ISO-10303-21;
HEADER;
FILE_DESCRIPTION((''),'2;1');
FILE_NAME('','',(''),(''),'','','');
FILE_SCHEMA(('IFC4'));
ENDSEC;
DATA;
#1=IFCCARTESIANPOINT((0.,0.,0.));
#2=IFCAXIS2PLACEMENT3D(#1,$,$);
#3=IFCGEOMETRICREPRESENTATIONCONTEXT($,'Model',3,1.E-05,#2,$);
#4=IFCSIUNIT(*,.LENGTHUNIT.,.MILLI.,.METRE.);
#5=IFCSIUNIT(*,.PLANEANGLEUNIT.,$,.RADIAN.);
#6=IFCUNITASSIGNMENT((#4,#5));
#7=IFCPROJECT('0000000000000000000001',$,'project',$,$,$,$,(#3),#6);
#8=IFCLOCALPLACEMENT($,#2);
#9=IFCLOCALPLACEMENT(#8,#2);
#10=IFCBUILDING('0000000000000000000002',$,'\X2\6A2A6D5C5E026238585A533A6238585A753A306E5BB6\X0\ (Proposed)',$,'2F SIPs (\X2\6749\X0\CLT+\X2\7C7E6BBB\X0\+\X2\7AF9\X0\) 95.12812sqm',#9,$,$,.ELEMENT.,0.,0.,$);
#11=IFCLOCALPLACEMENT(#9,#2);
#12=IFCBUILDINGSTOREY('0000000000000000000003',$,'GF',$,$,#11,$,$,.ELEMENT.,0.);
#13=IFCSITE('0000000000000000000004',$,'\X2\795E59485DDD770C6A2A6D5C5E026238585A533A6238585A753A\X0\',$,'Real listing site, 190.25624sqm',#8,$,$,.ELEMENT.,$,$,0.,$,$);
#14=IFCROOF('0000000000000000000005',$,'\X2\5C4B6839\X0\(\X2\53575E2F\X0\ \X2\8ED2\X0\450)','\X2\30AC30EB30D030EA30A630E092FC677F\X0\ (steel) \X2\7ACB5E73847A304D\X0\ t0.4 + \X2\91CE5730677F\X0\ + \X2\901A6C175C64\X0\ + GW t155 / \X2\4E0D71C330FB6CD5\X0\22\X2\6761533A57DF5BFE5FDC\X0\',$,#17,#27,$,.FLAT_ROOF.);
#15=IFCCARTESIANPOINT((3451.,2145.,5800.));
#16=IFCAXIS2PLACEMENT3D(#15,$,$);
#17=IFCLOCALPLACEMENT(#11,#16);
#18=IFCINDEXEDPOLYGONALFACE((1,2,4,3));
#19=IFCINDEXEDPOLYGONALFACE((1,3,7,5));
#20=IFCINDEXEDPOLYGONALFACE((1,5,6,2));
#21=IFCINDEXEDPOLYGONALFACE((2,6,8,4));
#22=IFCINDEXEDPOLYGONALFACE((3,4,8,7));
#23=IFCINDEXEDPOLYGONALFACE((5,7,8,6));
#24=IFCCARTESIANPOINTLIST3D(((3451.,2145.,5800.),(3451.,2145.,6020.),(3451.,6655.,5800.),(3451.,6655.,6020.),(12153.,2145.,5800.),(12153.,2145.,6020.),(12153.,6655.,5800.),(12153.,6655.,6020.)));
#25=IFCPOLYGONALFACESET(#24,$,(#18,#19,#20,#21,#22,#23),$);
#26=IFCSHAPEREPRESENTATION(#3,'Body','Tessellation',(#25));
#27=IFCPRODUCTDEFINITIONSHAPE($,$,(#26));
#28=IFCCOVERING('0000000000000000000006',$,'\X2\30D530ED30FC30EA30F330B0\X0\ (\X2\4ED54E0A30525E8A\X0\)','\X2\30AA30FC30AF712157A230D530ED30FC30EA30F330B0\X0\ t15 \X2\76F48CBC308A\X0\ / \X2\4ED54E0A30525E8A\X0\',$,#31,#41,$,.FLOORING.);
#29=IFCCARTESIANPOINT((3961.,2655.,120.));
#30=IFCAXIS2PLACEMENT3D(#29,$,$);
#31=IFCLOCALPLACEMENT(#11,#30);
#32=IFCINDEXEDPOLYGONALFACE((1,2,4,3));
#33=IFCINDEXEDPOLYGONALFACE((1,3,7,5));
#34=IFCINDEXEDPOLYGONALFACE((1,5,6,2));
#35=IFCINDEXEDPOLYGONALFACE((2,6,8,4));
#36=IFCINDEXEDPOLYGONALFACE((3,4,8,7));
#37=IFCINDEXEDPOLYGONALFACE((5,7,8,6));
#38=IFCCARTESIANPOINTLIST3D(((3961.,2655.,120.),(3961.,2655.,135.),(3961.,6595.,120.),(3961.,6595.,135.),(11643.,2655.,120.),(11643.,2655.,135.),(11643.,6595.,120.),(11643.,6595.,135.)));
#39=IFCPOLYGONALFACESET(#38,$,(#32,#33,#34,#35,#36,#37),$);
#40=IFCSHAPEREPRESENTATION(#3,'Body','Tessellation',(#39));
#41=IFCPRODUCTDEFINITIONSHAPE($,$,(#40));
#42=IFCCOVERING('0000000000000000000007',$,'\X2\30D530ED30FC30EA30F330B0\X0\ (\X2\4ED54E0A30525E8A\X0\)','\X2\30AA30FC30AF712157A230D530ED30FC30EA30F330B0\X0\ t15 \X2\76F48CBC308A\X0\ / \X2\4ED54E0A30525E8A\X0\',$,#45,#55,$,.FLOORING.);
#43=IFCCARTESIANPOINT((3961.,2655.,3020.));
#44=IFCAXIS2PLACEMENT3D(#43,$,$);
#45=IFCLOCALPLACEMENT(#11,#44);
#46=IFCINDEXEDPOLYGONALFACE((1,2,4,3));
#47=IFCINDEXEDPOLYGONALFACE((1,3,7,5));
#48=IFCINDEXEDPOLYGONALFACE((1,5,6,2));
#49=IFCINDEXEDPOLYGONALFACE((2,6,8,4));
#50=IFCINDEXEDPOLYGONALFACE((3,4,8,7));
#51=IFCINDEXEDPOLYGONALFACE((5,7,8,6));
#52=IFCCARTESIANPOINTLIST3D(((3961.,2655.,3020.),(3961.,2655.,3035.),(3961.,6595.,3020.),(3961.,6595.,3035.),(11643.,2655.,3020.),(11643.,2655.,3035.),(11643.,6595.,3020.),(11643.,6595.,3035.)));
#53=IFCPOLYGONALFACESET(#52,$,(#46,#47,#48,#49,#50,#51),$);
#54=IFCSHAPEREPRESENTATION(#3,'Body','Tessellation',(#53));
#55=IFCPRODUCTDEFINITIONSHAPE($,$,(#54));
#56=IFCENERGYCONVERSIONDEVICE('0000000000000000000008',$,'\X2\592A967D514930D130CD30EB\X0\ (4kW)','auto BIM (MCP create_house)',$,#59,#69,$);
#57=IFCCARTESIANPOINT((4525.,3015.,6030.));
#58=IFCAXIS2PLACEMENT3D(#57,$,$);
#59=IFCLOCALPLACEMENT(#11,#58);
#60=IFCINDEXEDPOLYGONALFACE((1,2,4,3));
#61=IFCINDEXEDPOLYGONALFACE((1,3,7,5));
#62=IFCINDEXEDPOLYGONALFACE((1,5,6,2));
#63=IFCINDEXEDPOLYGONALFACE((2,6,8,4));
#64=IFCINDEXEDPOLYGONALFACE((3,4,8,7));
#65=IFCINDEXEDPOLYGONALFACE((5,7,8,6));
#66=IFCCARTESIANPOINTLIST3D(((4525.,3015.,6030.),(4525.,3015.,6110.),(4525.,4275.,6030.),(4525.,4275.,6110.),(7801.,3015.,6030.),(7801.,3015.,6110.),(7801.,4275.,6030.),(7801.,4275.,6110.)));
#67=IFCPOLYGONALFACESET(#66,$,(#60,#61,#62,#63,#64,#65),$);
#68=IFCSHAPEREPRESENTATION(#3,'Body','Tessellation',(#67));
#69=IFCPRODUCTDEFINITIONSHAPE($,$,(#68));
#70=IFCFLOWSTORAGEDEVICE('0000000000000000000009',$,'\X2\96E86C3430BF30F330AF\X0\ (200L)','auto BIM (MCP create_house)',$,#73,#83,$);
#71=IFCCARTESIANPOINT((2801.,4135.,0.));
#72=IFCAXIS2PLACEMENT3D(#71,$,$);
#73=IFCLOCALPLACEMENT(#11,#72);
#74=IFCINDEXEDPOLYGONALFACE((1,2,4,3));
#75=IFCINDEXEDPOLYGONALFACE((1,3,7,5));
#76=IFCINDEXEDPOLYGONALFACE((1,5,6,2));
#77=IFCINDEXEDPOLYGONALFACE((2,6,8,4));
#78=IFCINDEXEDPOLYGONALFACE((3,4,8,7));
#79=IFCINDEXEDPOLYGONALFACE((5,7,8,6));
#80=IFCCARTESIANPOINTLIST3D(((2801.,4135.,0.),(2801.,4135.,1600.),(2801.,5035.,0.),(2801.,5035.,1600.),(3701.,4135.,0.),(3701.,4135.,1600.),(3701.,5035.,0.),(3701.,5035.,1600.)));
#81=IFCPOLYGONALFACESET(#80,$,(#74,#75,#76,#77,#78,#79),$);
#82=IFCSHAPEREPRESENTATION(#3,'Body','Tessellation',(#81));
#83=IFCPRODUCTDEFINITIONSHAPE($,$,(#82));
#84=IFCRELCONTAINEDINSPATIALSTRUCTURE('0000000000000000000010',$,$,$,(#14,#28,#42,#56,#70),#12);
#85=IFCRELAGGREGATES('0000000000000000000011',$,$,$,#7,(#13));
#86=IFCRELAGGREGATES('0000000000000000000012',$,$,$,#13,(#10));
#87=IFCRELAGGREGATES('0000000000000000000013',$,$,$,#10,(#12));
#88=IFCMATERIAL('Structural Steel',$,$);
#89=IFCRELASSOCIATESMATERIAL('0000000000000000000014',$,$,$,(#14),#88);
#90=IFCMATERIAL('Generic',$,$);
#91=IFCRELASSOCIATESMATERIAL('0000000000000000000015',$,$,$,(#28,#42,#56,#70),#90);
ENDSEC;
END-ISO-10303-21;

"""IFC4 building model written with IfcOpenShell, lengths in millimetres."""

from ifc_helpers import new_model, si_unit, frame, frame_2d, origin, place, context, project, spatial, rectangle, extrude, material, element, save


model = new_model("IFC4")

# Units and contexts
model_context = context("Model", 3, precision=1e-05, world=origin())
ifc_project = project(units=[si_unit("LENGTHUNIT", "METRE", prefix="MILLI"), si_unit("PLANEANGLEUNIT", "RADIAN")], contexts=[model_context])

# Site, building, storey
site_placement = place(None, origin())
site = spatial("IfcSite", under=ifc_project, at=site_placement, Name="神奈川県横浜市戸塚区戸塚町", ObjectType="Real listing site, 190.25624sqm", CompositionType="ELEMENT", RefElevation=0.0)
building_placement = place(site_placement, origin())
building = spatial("IfcBuilding", under=site, at=building_placement, Name="横浜市戸塚区戸塚町の家 (Proposed)", ObjectType="2F SIPs (杉CLT+籾殻+竹) 95.12812sqm", CompositionType="ELEMENT", ElevationOfRefHeight=0.0, ElevationOfTerrain=0.0)
storey_placement = place(building_placement, origin())
storey = spatial("IfcBuildingStorey", under=building, at=storey_placement, Name="GF", CompositionType="ELEMENT", Elevation=0.0)

# Roof
ifc_material_1 = material(Name="Structural Steel")
for number, where, name in (
    (1, (3451.0, 2145.0, 5800.0), "屋根(南帯 軒450)"),
):
    element("IfcRoof", number, at=place(storey_placement, frame(where)), inside=storey, material=ifc_material_1, Name=name, Description="ガルバリウム鋼板 (steel) 立平葺き t0.4 + 野地板 + 通気層 + GW t155 / 不燃・法22条区域対応", PredefinedType="FLAT_ROOF", context=model_context, shape_type="SweptSolid", body=[
        extrude(rectangle(XDim=8702.0, YDim=4510.0, at=frame_2d((4351.0, 2255.0))), frame((3451.0, 2145.0, 5800.0)), (0.0, 0.0, 1.0), 220.0),
    ])

# Coverings
ifc_material_2 = material(Name="Generic")
covering_1_placement = place(storey_placement, frame((3961.0, 2655.0, 120.0)))
element("IfcCovering", 2, at=covering_1_placement, inside=storey, material=ifc_material_2, Name="フローリング (仕上げ床)", Description="オーク無垢フローリング t15 直貼り / 仕上げ床", PredefinedType="FLOORING", context=model_context, shape_type="SweptSolid", body=[
    extrude(rectangle(XDim=7682.0, YDim=3940.0, at=frame_2d((3841.0, 1970.0))), frame((3961.0, 2655.0, 120.0)), (0.0, 0.0, 1.0), 15.0),
])
covering_2_placement = place(storey_placement, frame((3961.0, 2655.0, 3020.0)))
element("IfcCovering", 3, at=covering_2_placement, inside=storey, material=ifc_material_2, Name="フローリング (仕上げ床)", Description="オーク無垢フローリング t15 直貼り / 仕上げ床", PredefinedType="FLOORING", context=model_context, shape_type="SweptSolid", body=[
    extrude(rectangle(XDim=7682.0, YDim=3940.0, at=frame_2d((3841.0, 1970.0))), frame((3961.0, 2655.0, 3020.0)), (0.0, 0.0, 1.0), 15.0),
])

# Energy conversion device
energy_conversion_device_placement = place(storey_placement, frame((4525.0, 3015.0, 6030.0)))
element("IfcEnergyConversionDevice", 4, at=energy_conversion_device_placement, inside=storey, material=ifc_material_2, Name="太陽光パネル (4kW)", Description="auto BIM (MCP create_house)", context=model_context, shape_type="SweptSolid", body=[
    extrude(rectangle(XDim=3276.0, YDim=1260.0, at=frame_2d((1638.0, 630.0))), frame((4525.0, 3015.0, 6030.0)), (0.0, 0.0, 1.0), 80.0),
])

# Flow storage device
flow_storage_device_placement = place(storey_placement, frame((2801.0, 4135.0, 0.0)))
element("IfcFlowStorageDevice", 5, at=flow_storage_device_placement, inside=storey, material=ifc_material_2, Name="雨水タンク (200L)", Description="auto BIM (MCP create_house)", context=model_context, shape_type="SweptSolid", body=[
    extrude(rectangle(XDim=900.0, YDim=900.0, at=frame_2d((450.0, 450.0))), frame((2801.0, 4135.0, 0.0)), (0.0, 0.0, 1.0), 1600.0),
])

save(model, "model.ifc")
